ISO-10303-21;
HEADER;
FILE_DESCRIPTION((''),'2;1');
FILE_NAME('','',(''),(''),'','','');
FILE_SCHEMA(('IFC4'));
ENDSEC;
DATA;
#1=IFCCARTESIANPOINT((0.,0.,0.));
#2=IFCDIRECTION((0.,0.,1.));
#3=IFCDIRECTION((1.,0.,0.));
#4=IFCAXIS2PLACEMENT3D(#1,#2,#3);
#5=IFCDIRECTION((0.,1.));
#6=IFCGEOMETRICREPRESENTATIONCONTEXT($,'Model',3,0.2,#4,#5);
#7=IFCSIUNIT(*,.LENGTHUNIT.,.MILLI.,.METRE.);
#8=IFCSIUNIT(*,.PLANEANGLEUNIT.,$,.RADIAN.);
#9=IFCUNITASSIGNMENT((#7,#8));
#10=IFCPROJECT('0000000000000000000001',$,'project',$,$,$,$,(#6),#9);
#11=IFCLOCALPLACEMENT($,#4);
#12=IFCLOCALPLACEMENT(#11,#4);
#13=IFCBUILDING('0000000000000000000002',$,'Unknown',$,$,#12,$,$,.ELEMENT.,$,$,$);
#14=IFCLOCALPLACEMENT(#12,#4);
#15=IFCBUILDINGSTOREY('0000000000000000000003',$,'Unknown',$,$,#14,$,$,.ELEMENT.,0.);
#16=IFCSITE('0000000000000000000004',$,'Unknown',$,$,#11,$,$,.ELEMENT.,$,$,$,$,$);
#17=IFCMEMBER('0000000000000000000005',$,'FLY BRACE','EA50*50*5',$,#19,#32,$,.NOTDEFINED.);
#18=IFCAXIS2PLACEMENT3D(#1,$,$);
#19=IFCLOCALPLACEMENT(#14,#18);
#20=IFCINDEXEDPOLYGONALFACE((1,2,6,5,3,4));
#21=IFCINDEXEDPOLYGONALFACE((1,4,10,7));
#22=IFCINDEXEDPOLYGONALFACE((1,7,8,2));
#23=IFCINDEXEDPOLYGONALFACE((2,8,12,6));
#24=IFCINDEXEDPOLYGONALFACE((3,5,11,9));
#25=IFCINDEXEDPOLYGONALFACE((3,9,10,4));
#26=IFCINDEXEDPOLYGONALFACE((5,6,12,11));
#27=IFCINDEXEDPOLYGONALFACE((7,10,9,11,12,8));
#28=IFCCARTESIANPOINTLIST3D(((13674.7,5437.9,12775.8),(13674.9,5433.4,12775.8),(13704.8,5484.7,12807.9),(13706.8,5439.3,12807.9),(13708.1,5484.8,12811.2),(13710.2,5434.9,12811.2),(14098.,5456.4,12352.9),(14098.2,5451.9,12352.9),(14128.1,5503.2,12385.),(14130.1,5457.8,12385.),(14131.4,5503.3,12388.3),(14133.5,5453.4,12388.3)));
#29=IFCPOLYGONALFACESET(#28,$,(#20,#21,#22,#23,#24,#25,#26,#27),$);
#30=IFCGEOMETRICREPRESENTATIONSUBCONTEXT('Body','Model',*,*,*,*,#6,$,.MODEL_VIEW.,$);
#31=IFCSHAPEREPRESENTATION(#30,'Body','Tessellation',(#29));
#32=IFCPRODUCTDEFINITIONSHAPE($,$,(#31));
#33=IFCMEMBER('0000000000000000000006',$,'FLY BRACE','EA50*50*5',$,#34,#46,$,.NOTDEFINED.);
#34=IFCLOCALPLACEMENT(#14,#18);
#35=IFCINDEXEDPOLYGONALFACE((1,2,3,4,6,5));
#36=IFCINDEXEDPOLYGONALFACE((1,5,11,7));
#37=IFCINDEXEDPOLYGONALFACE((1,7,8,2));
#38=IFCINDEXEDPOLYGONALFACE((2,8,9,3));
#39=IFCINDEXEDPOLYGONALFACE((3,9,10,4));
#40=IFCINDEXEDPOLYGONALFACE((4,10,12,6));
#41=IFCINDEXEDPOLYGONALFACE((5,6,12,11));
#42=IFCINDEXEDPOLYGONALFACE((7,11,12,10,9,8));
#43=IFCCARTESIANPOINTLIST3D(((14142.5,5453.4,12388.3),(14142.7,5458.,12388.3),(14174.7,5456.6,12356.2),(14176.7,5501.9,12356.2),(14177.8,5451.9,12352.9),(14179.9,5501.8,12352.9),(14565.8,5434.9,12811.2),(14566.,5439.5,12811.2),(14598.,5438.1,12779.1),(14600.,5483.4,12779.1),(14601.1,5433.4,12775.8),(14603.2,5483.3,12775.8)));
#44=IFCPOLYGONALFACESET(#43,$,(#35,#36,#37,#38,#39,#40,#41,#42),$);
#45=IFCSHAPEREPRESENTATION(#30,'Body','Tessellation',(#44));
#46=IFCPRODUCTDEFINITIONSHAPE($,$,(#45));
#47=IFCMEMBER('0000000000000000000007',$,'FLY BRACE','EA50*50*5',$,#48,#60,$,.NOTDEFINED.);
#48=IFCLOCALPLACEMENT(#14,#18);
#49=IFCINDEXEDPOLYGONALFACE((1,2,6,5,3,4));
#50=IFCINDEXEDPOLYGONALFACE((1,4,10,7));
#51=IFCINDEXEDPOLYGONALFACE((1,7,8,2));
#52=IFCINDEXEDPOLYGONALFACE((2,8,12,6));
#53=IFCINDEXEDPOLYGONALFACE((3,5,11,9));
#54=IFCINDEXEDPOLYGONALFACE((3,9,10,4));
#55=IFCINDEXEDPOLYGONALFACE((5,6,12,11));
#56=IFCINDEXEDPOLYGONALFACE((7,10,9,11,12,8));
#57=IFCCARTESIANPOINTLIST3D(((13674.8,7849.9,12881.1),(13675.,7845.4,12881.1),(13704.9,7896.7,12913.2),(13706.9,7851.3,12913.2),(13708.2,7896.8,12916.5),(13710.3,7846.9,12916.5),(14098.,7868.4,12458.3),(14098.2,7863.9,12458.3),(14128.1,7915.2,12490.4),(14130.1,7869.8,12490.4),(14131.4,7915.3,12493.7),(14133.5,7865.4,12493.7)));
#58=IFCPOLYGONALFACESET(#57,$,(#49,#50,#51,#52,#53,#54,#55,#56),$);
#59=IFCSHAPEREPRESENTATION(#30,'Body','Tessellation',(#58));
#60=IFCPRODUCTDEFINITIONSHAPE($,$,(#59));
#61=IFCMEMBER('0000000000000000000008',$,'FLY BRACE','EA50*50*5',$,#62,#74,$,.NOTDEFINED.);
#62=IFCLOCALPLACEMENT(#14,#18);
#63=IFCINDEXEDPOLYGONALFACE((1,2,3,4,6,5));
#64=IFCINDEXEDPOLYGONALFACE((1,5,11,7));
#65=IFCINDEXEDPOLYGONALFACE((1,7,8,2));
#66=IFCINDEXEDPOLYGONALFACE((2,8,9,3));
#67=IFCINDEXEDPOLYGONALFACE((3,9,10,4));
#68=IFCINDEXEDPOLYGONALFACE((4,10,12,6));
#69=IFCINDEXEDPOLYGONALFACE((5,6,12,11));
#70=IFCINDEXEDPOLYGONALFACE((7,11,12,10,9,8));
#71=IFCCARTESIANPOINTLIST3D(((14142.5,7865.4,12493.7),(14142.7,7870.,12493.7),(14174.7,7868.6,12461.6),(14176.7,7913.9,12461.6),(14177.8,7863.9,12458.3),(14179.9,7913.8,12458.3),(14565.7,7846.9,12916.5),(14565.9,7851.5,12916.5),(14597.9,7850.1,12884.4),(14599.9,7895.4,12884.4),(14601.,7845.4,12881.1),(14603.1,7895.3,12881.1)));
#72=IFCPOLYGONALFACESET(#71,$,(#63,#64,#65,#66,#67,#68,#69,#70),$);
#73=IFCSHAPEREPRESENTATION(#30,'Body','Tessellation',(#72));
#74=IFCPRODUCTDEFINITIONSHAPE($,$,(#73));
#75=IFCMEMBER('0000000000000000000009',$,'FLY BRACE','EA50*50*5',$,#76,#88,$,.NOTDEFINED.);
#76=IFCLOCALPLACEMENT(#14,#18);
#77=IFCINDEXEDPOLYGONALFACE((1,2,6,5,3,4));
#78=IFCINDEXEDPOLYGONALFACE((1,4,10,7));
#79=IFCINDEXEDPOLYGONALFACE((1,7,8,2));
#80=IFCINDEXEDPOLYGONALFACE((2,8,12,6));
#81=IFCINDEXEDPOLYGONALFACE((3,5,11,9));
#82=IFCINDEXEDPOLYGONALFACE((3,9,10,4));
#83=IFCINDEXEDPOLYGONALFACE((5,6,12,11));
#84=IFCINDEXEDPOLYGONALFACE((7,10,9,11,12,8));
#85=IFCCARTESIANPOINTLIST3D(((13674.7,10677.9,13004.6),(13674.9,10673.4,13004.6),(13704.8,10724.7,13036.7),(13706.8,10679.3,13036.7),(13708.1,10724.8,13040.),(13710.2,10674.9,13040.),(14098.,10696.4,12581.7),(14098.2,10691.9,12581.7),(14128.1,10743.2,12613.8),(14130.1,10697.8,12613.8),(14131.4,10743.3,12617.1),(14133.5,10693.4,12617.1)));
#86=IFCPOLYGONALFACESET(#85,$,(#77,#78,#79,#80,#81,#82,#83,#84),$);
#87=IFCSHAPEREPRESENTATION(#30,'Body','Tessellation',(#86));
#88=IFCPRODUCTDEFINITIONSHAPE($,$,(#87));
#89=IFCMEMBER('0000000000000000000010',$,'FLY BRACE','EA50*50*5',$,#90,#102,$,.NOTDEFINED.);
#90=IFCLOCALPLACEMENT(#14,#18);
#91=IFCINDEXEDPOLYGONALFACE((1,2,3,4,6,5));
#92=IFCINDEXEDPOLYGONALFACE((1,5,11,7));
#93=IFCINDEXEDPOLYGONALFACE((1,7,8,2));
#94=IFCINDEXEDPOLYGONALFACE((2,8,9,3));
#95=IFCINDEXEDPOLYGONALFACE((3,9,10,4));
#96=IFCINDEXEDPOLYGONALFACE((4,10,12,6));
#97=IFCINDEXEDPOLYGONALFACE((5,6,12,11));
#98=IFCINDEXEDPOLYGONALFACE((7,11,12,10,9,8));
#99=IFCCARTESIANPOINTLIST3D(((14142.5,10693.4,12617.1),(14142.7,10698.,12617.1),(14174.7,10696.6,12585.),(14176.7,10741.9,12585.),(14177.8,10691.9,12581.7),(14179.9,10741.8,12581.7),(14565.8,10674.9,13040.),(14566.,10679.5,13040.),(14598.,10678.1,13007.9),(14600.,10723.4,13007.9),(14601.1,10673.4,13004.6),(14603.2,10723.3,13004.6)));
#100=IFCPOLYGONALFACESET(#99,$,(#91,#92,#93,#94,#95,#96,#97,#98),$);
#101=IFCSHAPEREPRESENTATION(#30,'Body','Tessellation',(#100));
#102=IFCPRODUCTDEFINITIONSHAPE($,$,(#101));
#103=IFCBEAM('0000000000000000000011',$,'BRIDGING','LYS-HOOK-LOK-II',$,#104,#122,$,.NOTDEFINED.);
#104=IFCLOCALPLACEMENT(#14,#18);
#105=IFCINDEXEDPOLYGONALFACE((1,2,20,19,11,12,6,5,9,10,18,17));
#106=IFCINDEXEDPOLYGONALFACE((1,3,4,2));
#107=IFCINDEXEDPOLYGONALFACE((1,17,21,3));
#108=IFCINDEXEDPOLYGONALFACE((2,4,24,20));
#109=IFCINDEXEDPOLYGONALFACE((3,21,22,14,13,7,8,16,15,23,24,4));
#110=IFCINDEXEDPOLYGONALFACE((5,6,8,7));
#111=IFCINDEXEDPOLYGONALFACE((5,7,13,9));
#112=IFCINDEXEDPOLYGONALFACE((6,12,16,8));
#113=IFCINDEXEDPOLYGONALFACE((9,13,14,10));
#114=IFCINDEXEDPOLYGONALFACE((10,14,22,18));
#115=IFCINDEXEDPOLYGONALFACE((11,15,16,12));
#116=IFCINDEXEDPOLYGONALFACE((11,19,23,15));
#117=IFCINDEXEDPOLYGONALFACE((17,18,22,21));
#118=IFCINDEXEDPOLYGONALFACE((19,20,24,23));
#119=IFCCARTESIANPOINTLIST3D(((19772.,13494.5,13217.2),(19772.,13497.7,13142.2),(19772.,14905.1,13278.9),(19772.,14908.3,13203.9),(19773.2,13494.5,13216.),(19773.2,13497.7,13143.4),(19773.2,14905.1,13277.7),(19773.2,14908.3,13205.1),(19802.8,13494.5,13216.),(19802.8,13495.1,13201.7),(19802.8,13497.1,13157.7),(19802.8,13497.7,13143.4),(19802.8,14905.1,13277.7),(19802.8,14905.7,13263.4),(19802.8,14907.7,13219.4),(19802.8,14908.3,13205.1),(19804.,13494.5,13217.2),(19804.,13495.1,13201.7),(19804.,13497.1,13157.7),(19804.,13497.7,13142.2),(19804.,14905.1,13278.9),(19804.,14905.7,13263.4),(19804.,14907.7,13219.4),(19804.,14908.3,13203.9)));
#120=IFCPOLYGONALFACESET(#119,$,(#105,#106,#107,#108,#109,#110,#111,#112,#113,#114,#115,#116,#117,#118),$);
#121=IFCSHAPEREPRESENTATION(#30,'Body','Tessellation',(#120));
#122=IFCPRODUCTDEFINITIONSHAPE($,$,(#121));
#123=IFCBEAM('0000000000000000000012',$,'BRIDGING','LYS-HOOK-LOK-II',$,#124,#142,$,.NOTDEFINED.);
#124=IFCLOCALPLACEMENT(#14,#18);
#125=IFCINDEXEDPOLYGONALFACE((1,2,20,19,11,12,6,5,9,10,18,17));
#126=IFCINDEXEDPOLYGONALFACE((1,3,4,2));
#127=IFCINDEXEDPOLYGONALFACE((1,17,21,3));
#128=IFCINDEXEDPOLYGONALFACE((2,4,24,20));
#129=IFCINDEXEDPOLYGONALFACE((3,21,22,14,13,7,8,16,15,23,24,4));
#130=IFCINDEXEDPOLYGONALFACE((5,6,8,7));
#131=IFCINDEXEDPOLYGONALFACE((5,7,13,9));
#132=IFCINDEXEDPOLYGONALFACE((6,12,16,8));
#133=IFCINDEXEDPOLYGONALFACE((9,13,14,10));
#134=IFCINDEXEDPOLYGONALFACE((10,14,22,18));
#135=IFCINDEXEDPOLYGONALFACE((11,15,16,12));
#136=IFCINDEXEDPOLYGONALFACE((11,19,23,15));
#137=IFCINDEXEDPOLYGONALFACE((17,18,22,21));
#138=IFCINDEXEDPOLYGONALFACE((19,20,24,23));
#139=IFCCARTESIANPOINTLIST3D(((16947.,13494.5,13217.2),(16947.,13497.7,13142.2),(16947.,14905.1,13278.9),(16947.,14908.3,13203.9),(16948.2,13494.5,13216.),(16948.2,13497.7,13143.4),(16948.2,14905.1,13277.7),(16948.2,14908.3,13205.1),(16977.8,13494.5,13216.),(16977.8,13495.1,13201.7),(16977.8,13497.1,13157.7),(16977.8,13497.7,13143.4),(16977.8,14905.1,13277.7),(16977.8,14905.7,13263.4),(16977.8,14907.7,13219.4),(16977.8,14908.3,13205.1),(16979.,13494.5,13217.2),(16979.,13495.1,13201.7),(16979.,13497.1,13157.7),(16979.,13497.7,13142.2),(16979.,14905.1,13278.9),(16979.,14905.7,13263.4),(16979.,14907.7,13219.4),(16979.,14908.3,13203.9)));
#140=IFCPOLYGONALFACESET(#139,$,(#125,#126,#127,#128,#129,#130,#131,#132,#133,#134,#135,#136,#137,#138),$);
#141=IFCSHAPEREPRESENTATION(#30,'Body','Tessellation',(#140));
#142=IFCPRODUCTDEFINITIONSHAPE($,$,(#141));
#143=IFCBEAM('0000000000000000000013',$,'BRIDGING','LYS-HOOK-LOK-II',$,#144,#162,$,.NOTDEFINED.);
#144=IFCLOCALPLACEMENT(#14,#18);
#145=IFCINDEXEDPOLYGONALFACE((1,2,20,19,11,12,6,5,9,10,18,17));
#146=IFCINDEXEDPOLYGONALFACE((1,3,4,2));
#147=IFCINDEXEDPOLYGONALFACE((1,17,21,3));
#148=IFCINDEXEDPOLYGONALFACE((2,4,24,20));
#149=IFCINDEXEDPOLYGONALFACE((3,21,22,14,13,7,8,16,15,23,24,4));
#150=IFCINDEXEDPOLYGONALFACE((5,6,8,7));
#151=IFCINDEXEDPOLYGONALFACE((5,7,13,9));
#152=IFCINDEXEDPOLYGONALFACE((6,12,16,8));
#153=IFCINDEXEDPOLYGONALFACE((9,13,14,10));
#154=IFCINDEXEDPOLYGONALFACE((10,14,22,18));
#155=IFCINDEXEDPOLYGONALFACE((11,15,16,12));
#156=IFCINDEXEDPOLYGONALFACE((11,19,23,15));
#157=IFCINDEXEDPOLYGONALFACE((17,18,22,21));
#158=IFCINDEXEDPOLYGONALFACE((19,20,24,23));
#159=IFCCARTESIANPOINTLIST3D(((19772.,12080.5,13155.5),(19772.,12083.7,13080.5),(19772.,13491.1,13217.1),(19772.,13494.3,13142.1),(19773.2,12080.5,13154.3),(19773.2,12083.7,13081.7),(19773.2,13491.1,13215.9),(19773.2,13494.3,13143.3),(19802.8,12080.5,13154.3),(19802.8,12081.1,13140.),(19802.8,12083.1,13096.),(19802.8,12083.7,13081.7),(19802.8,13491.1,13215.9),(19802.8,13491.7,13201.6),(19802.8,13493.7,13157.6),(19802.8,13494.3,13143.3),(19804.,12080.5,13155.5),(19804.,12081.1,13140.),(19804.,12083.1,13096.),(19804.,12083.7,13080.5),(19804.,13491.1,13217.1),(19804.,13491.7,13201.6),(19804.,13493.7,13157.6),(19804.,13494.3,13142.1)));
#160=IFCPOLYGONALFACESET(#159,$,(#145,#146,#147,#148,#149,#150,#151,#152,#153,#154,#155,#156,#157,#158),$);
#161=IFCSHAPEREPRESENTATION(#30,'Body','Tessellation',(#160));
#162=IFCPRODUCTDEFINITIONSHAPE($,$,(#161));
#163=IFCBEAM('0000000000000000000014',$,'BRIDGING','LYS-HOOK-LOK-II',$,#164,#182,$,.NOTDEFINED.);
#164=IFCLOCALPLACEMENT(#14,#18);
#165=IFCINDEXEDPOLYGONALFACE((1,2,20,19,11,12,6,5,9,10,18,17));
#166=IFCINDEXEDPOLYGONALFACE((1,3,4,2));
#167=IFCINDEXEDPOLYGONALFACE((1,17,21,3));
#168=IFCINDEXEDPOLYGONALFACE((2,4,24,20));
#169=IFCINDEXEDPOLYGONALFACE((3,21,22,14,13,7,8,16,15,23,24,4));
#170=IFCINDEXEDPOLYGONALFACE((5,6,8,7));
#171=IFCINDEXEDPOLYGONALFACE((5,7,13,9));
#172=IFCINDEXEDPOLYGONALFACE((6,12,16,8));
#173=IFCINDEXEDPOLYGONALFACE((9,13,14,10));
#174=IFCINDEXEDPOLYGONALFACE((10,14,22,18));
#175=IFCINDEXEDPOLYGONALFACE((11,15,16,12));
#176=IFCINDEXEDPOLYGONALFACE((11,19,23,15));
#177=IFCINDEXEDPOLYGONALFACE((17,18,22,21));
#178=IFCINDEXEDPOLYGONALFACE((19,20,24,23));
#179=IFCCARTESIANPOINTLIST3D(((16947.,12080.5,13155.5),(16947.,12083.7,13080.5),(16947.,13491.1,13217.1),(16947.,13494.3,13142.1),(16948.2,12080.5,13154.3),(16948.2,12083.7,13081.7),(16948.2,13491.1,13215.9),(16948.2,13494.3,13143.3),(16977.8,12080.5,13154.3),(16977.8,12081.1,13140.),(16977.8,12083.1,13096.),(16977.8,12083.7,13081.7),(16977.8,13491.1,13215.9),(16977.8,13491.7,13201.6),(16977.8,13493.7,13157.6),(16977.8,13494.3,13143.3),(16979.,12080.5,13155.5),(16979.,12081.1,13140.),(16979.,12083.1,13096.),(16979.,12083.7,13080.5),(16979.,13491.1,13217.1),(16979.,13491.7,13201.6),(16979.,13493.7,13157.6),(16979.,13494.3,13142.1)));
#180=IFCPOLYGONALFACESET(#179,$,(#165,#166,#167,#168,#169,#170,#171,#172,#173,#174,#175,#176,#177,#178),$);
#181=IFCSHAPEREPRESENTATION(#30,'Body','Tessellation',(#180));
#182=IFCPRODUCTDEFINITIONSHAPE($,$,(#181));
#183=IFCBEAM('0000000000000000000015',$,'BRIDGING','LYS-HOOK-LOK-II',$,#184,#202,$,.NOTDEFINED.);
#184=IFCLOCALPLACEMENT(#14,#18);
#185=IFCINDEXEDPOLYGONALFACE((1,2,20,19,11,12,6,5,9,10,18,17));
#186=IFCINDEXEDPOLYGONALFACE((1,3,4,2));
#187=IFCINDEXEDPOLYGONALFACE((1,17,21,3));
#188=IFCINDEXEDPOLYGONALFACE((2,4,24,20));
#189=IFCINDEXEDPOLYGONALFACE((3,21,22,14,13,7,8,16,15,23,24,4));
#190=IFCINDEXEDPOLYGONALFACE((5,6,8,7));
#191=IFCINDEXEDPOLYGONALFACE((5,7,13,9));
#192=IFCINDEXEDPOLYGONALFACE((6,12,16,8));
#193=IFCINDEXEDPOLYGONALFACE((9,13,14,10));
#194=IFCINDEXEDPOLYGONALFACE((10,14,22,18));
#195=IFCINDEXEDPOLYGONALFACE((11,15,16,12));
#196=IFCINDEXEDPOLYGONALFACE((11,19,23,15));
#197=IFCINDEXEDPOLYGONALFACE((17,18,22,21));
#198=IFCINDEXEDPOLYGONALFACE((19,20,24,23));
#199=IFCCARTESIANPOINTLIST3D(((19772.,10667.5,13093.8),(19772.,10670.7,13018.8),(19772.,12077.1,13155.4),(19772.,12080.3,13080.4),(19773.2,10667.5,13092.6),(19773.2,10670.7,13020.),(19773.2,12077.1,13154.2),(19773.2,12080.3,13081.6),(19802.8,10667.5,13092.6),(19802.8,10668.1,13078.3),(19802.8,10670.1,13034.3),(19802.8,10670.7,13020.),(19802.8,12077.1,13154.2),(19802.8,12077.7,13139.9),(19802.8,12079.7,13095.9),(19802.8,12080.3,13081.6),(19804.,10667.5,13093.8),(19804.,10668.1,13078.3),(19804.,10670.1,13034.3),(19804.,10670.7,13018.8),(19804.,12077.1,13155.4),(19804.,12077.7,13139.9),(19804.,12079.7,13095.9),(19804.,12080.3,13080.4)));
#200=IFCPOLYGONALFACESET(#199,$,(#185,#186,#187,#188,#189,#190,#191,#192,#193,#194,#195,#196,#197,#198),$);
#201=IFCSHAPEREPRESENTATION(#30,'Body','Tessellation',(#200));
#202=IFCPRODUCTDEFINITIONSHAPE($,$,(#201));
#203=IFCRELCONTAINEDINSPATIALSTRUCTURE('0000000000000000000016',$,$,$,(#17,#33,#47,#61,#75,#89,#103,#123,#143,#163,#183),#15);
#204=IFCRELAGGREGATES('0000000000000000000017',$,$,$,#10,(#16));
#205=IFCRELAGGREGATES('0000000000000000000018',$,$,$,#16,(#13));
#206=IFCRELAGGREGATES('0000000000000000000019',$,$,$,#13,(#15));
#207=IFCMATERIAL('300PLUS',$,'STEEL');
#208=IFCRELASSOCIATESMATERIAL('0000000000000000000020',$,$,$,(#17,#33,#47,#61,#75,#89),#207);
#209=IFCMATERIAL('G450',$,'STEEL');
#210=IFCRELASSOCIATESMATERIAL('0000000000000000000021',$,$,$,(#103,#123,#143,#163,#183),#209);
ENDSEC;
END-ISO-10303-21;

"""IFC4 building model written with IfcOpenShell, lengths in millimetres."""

from ifc_helpers import new_model, si_unit, direction, frame, origin_with_axes, place, context, subcontext, project, spatial, line, indexed_curve, outline, extrude, material, element, save


model = new_model("IFC4")

# Units and contexts
model_context = context("Model", 3, precision=0.2, world=origin_with_axes(), true_north=direction((0.0, 1.0)))
body_context = subcontext(model_context, "Body", "Model", "MODEL_VIEW")
ifc_project = project(units=[si_unit("LENGTHUNIT", "METRE", prefix="MILLI"), si_unit("PLANEANGLEUNIT", "RADIAN")], contexts=[model_context])

# Site, building, storey
site_placement = place(None, origin_with_axes())
site = spatial("IfcSite", under=ifc_project, at=site_placement, Name="Unknown", CompositionType="ELEMENT")
building_placement = place(site_placement, origin_with_axes())
building = spatial("IfcBuilding", under=site, at=building_placement, Name="Unknown", CompositionType="ELEMENT")
storey_placement = place(building_placement, origin_with_axes())
storey = spatial("IfcBuildingStorey", under=building, at=storey_placement, Name="Unknown", CompositionType="ELEMENT", Elevation=0.0)

# Members
ifc_material_1 = material(Name="300PLUS", Category="STEEL")
for number, where, z_axis, x_axis, name in (
    (1, (14114.8, 5477.6, 12370.6), (-0.705761, -0.030845, -0.707778), (-0.707103, -0.030903, 0.706435), "FLY BRACE"),
    (2, (14161.2, 5477.6, 12370.6), (-0.705761, 0.030845, 0.707778), (0.707103, -0.030903, 0.706435), "FLY BRACE"),
):
    element("IfcMember", number, at=place(storey_placement, frame(where, z_axis=z_axis, x_axis=x_axis)), inside=storey, material=ifc_material_1, Name=name, Description="EA50*50*5", PredefinedType="NOTDEFINED", context=body_context, shape_type="SolidModel", body=[
        extrude(outline(indexed_curve([(-25.0, -25.0), (25.0, -25.0), (25.0, -20.4), (-20.4, -20.4), (-20.4, 25.0), (-25.0, 25.0)], segments=[line(1, 2, 3, 4, 5, 6, 1)])), frame((0.0, 0.0, 0.0), z_axis=(-1.0, 0.0, 0.0), x_axis=(0.0, 0.0, 1.0)), (0.0, 0.0, -1.0), 598.6),
    ])
for number, where, z_axis, x_axis, name in (
    (3, (14114.8, 7889.6, 12476.0), (-0.705761, -0.030852, -0.707778), (-0.707103, -0.030911, 0.706435), "FLY BRACE"),
    (4, (14161.2, 7889.6, 12476.0), (-0.705761, 0.030852, 0.707778), (0.707103, -0.030911, 0.706435), "FLY BRACE"),
):
    element("IfcMember", number, at=place(storey_placement, frame(where, z_axis=z_axis, x_axis=x_axis)), inside=storey, material=ifc_material_1, Name=name, Description="EA50*50*5", PredefinedType="NOTDEFINED", context=body_context, shape_type="SolidModel", body=[
        extrude(outline(indexed_curve([(-25.0, -25.0), (25.0, -25.0), (25.0, -20.4), (-20.4, -20.4), (-20.4, 25.0), (-25.0, 25.0)], segments=[line(1, 2, 3, 4, 5, 6, 1)])), frame((0.0, 0.0, 0.0), z_axis=(-1.0, 0.0, 0.0), x_axis=(0.0, 0.0, 1.0)), (0.0, 0.0, -1.0), 598.5),
    ])
for number, where, z_axis, x_axis, name in (
    (5, (14114.8, 10717.6, 12599.4), (-0.705761, -0.030845, -0.707778), (-0.707103, -0.030903, 0.706435), "FLY BRACE"),
    (6, (14161.2, 10717.6, 12599.4), (-0.705761, 0.030845, 0.707778), (0.707103, -0.030903, 0.706435), "FLY BRACE"),
):
    element("IfcMember", number, at=place(storey_placement, frame(where, z_axis=z_axis, x_axis=x_axis)), inside=storey, material=ifc_material_1, Name=name, Description="EA50*50*5", PredefinedType="NOTDEFINED", context=body_context, shape_type="SolidModel", body=[
        extrude(outline(indexed_curve([(-25.0, -25.0), (25.0, -25.0), (25.0, -20.4), (-20.4, -20.4), (-20.4, 25.0), (-25.0, 25.0)], segments=[line(1, 2, 3, 4, 5, 6, 1)])), frame((0.0, 0.0, 0.0), z_axis=(-1.0, 0.0, 0.0), x_axis=(0.0, 0.0, 1.0)), (0.0, 0.0, -1.0), 598.6),
    ])

# Beams
ifc_material_2 = material(Name="G450", Category="STEEL")
for number, where, z_axis, x_axis, name in (
    (7, (19788.0, 13496.1, 13179.7), (1.0, 0.0, 0.0), (0.0, 0.999045, 0.043698), "BRIDGING"),
    (8, (16963.0, 13496.1, 13179.7), (1.0, 0.0, 0.0), (0.0, 0.999045, 0.043698), "BRIDGING"),
):
    element("IfcBeam", number, at=place(storey_placement, frame(where, z_axis=z_axis, x_axis=x_axis)), inside=storey, material=ifc_material_2, Name=name, Description="LYS-HOOK-LOK-II", PredefinedType="NOTDEFINED", context=body_context, shape_type="SolidModel", body=[
        extrude(outline(indexed_curve([(16.0, -37.5), (16.0, -22.0), (14.8, -22.0), (14.8, -36.3), (-14.8, -36.3), (-14.8, 36.3), (14.8, 36.3), (14.8, 22.0), (16.0, 22.0), (16.0, 37.5), (-16.0, 37.5), (-16.0, -37.5)], segments=[line(1, 2, 3, 4, 5, 6, 7, 8, 9, 10, 11, 12, 1)])), frame((0.0, 0.0, 0.0), z_axis=(-1.0, 0.0, 0.0), x_axis=(0.0, 0.0, 1.0)), (0.0, 0.0, -1.0), 1411.9),
    ])
for number, where, z_axis, x_axis, name in (
    (9, (19788.0, 12082.1, 13118.0), (1.0, 0.0, 0.0), (0.0, 0.999048, 0.043628), "BRIDGING"),
    (10, (16963.0, 12082.1, 13118.0), (1.0, 0.0, 0.0), (0.0, 0.999048, 0.043628), "BRIDGING"),
):
    element("IfcBeam", number, at=place(storey_placement, frame(where, z_axis=z_axis, x_axis=x_axis)), inside=storey, material=ifc_material_2, Name=name, Description="LYS-HOOK-LOK-II", PredefinedType="NOTDEFINED", context=body_context, shape_type="SolidModel", body=[
        extrude(outline(indexed_curve([(16.0, -37.5), (16.0, -22.0), (14.8, -22.0), (14.8, -36.3), (-14.8, -36.3), (-14.8, 36.3), (14.8, 36.3), (14.8, 22.0), (16.0, 22.0), (16.0, 37.5), (-16.0, 37.5), (-16.0, -37.5)], segments=[line(1, 2, 3, 4, 5, 6, 7, 8, 9, 10, 11, 12, 1)])), frame((0.0, 0.0, 0.0), z_axis=(-1.0, 0.0, 0.0), x_axis=(0.0, 0.0, 1.0)), (0.0, 0.0, -1.0), 1411.9),
    ])
for number, where, z_axis, x_axis, name in (
    (11, (19788.0, 10669.1, 13056.3), (1.0, 0.0, 0.0), (0.0, 0.999047, 0.043659), "BRIDGING"),
):
    element("IfcBeam", number, at=place(storey_placement, frame(where, z_axis=z_axis, x_axis=x_axis)), inside=storey, material=ifc_material_2, Name=name, Description="LYS-HOOK-LOK-II", PredefinedType="NOTDEFINED", context=body_context, shape_type="SolidModel", body=[
        extrude(outline(indexed_curve([(16.0, -37.5), (16.0, -22.0), (14.8, -22.0), (14.8, -36.3), (-14.8, -36.3), (-14.8, 36.3), (14.8, 36.3), (14.8, 22.0), (16.0, 22.0), (16.0, 37.5), (-16.0, 37.5), (-16.0, -37.5)], segments=[line(1, 2, 3, 4, 5, 6, 7, 8, 9, 10, 11, 12, 1)])), frame((0.0, 0.0, 0.0), z_axis=(-1.0, 0.0, 0.0), x_axis=(0.0, 0.0, 1.0)), (0.0, 0.0, -1.0), 1410.9),
    ])

save(model, "model.ifc")
